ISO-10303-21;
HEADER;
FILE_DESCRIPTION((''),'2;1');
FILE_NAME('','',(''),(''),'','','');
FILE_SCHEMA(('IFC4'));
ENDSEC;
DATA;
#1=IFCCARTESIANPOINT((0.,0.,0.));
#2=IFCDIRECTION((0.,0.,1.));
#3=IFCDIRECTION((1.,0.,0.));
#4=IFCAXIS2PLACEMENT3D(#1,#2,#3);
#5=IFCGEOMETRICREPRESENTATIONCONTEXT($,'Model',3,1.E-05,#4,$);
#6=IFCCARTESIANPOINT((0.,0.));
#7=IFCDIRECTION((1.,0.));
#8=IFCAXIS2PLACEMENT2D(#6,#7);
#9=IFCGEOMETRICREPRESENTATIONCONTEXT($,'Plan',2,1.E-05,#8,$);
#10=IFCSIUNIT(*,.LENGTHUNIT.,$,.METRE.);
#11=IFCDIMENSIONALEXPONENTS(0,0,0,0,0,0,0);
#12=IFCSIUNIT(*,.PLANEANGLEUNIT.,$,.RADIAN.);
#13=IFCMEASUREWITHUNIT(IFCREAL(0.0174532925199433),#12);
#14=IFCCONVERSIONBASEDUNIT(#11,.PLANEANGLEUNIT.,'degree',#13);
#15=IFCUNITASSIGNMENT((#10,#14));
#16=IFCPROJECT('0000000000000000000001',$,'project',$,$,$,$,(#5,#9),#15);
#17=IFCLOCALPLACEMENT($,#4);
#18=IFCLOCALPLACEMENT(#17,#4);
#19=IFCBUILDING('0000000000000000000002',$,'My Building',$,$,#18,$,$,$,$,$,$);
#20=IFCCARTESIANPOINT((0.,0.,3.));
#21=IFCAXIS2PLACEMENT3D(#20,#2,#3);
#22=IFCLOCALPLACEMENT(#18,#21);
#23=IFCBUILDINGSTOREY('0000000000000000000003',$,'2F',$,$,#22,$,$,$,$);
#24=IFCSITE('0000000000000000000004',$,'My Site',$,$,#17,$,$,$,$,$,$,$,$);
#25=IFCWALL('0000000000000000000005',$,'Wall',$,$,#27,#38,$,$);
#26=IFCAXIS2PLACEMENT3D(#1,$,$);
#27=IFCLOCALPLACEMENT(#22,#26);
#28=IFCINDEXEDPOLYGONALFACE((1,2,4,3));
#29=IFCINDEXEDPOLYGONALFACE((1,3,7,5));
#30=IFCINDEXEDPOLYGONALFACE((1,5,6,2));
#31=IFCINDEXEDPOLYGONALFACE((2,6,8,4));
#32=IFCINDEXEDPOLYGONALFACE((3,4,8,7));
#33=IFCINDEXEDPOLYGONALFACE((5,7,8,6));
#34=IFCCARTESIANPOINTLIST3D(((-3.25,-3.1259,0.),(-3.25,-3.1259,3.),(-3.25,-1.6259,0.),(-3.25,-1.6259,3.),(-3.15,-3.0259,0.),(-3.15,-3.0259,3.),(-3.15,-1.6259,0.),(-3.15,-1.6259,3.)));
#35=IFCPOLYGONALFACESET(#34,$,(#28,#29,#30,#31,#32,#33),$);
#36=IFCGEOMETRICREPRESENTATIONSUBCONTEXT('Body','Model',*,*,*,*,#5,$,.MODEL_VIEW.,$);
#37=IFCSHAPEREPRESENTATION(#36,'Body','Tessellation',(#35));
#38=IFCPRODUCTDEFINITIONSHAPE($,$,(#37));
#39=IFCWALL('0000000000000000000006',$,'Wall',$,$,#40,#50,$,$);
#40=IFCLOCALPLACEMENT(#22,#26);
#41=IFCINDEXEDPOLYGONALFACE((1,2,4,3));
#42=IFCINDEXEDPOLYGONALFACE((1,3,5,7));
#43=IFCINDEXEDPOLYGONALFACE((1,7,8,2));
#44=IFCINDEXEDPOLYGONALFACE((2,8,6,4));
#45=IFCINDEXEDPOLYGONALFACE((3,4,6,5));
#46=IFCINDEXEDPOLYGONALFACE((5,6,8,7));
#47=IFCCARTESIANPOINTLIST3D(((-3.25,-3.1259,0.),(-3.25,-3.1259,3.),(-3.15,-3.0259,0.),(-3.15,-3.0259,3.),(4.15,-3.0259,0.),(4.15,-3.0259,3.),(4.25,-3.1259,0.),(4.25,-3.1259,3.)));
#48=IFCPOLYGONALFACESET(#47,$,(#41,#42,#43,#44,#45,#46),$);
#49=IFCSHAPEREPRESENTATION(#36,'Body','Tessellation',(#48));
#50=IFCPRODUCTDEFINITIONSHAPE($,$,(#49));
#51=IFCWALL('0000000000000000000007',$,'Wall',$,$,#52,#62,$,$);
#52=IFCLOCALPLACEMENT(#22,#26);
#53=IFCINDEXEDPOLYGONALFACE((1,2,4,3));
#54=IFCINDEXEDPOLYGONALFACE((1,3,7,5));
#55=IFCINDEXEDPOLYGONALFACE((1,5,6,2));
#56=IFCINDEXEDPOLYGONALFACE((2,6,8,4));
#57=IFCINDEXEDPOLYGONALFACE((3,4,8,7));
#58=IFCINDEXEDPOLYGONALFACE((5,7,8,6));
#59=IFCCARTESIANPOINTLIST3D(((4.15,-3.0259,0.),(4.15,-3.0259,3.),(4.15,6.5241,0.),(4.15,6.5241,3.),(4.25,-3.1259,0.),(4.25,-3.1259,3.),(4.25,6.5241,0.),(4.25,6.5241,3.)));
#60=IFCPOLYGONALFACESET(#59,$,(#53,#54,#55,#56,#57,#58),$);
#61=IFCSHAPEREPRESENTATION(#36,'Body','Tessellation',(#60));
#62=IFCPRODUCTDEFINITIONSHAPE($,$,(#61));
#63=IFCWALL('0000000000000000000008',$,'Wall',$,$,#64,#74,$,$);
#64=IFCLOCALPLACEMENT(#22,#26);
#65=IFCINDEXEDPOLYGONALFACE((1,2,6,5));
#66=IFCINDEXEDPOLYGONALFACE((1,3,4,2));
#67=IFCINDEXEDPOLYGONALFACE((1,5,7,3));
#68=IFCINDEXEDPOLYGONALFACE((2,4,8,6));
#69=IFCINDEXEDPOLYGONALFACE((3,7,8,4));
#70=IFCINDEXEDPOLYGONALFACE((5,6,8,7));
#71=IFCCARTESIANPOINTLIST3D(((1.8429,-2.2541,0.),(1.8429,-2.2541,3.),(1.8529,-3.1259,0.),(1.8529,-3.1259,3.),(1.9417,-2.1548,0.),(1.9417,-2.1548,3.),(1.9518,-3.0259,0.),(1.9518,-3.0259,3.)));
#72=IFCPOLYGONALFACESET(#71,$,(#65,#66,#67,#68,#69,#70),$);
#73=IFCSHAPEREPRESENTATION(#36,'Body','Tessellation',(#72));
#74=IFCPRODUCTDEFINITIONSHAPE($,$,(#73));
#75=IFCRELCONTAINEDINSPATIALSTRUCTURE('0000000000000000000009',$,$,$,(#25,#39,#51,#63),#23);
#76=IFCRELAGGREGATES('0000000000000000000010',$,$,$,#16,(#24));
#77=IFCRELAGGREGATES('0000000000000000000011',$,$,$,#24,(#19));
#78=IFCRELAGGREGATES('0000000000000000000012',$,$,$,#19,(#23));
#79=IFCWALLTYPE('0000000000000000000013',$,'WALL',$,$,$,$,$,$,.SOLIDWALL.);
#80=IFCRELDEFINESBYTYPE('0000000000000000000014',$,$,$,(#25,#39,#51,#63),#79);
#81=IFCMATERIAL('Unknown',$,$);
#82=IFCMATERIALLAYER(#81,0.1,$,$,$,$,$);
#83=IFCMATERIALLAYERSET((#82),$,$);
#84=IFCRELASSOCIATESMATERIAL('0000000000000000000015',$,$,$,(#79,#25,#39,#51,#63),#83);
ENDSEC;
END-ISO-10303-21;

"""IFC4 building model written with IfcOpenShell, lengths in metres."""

from ifc_helpers import new_model, entity, si_unit, converted_unit, frame, origin_with_axes, origin_2d_with_axis, place, context, subcontext, project, spatial, line, indexed_curve, outline, extrude, material, layer, layer_set, layer_usage, type_object, element, save


model = new_model("IFC4")

# Units and contexts
model_context = context("Model", 3, precision=1e-05, world=origin_with_axes())
plan_context = context("Plan", 2, precision=1e-05, world=origin_2d_with_axis())
body_context_1 = subcontext(model_context, "Body", "Model", "MODEL_VIEW")
ifc_project = project(units=[si_unit("LENGTHUNIT", "METRE"), converted_unit("PLANEANGLEUNIT", "degree", entity("IfcReal", 0.0174532925199433), si_unit("PLANEANGLEUNIT", "RADIAN"), dimensions=[0, 0, 0, 0, 0, 0, 0])], contexts=[model_context, plan_context])

# Site, building, storey
site_placement = place(None, origin_with_axes())
site = spatial("IfcSite", under=ifc_project, at=site_placement, Name="My Site")
building_placement = place(site_placement, origin_with_axes())
building = spatial("IfcBuilding", under=site, at=building_placement, Name="My Building")
storey_placement = place(building_placement, frame((0.0, 0.0, 3.0), z_axis=(0.0, 0.0, 1.0), x_axis=(1.0, 0.0, 0.0)))
storey = spatial("IfcBuildingStorey", under=building, at=storey_placement, Name="2F")

# Walls
ifc_material = material(Name="Unknown")
ifc_layer = layer(ifc_material, 0.1)
ifc_layer_set = layer_set([ifc_layer])
ifc_layer_usage_1 = layer_usage(ifc_layer_set, "AXIS2", "POSITIVE", 0.0)
wall_type = type_object("IfcWallType", Name="WALL", PredefinedType="SOLIDWALL", material=ifc_layer_set)
wall_1_placement = place(storey_placement, frame((-3.25, -1.6259, 0.0), z_axis=(0.0, 0.0, 1.0), x_axis=(0.0, -1.0, 0.0)))
element("IfcWall", 1, at=wall_1_placement, inside=storey, type_object=wall_type, material=ifc_layer_usage_1, Name="Wall", context=body_context_1, shape_type="SweptSolid", body=[
    extrude(outline(indexed_curve([(0.0, 0.0), (0.0, 0.1), (1.4, 0.1), (1.5, 0.0)], segments=[line(1, 2, 3, 4, 1)])), origin_with_axes(), (0.0, 0.0, 1.0), 3.0),
])
ifc_layer_usage_2 = layer_usage(ifc_layer_set, "AXIS2", "POSITIVE", 0.0)
wall_2_placement = place(storey_placement, frame((-3.25, -3.1259, 0.0), z_axis=(0.0, 0.0, 1.0), x_axis=(1.0, 0.0, 0.0)))
element("IfcWall", 2, at=wall_2_placement, inside=storey, type_object=wall_type, material=ifc_layer_usage_2, Name="Wall", context=body_context_1, shape_type="SweptSolid", body=[
    extrude(outline(indexed_curve([(0.0, 0.0), (0.1, 0.1), (7.4, 0.1), (7.5, 0.0)], segments=[line(1, 2, 3, 4, 1)])), origin_with_axes(), (0.0, 0.0, 1.0), 3.0),
])
ifc_layer_usage_3 = layer_usage(ifc_layer_set, "AXIS2", "POSITIVE", 0.0)
wall_3_placement = place(storey_placement, frame((4.25, -3.1259, 0.0), z_axis=(0.0, 0.0, 1.0), x_axis=(0.0, 1.0, 0.0)))
element("IfcWall", 3, at=wall_3_placement, inside=storey, type_object=wall_type, material=ifc_layer_usage_3, Name="Wall", context=body_context_1, shape_type="SweptSolid", body=[
    extrude(outline(indexed_curve([(0.0, 0.0), (0.1, 0.1), (9.65, 0.1), (9.65, 0.0)], segments=[line(1, 2, 3, 4, 1)])), origin_with_axes(), (0.0, 0.0, 1.0), 3.0),
])

# Wall
ifc_layer_usage_4 = layer_usage(ifc_layer_set, "AXIS2", "POSITIVE", 0.0)
wall_4_placement = place(storey_placement, frame((1.8429, -2.2541, 0.0), z_axis=(0.0, 0.0, 1.0), x_axis=(0.011526, -0.999934, 0.0)))
element("IfcWall", 4, at=wall_4_placement, inside=storey, type_object=wall_type, material=ifc_layer_usage_4, Name="Wall", context=body_context_1, shape_type="SweptSolid", body=[
    extrude(outline(indexed_curve([(0.0, 0.0), (-0.0982, 0.1), (0.773, 0.1), (0.8718, 0.0)], segments=[line(1, 2, 3, 4, 1)])), origin_with_axes(), (0.0, 0.0, 1.0), 3.0),
])

save(model, "model.ifc")
